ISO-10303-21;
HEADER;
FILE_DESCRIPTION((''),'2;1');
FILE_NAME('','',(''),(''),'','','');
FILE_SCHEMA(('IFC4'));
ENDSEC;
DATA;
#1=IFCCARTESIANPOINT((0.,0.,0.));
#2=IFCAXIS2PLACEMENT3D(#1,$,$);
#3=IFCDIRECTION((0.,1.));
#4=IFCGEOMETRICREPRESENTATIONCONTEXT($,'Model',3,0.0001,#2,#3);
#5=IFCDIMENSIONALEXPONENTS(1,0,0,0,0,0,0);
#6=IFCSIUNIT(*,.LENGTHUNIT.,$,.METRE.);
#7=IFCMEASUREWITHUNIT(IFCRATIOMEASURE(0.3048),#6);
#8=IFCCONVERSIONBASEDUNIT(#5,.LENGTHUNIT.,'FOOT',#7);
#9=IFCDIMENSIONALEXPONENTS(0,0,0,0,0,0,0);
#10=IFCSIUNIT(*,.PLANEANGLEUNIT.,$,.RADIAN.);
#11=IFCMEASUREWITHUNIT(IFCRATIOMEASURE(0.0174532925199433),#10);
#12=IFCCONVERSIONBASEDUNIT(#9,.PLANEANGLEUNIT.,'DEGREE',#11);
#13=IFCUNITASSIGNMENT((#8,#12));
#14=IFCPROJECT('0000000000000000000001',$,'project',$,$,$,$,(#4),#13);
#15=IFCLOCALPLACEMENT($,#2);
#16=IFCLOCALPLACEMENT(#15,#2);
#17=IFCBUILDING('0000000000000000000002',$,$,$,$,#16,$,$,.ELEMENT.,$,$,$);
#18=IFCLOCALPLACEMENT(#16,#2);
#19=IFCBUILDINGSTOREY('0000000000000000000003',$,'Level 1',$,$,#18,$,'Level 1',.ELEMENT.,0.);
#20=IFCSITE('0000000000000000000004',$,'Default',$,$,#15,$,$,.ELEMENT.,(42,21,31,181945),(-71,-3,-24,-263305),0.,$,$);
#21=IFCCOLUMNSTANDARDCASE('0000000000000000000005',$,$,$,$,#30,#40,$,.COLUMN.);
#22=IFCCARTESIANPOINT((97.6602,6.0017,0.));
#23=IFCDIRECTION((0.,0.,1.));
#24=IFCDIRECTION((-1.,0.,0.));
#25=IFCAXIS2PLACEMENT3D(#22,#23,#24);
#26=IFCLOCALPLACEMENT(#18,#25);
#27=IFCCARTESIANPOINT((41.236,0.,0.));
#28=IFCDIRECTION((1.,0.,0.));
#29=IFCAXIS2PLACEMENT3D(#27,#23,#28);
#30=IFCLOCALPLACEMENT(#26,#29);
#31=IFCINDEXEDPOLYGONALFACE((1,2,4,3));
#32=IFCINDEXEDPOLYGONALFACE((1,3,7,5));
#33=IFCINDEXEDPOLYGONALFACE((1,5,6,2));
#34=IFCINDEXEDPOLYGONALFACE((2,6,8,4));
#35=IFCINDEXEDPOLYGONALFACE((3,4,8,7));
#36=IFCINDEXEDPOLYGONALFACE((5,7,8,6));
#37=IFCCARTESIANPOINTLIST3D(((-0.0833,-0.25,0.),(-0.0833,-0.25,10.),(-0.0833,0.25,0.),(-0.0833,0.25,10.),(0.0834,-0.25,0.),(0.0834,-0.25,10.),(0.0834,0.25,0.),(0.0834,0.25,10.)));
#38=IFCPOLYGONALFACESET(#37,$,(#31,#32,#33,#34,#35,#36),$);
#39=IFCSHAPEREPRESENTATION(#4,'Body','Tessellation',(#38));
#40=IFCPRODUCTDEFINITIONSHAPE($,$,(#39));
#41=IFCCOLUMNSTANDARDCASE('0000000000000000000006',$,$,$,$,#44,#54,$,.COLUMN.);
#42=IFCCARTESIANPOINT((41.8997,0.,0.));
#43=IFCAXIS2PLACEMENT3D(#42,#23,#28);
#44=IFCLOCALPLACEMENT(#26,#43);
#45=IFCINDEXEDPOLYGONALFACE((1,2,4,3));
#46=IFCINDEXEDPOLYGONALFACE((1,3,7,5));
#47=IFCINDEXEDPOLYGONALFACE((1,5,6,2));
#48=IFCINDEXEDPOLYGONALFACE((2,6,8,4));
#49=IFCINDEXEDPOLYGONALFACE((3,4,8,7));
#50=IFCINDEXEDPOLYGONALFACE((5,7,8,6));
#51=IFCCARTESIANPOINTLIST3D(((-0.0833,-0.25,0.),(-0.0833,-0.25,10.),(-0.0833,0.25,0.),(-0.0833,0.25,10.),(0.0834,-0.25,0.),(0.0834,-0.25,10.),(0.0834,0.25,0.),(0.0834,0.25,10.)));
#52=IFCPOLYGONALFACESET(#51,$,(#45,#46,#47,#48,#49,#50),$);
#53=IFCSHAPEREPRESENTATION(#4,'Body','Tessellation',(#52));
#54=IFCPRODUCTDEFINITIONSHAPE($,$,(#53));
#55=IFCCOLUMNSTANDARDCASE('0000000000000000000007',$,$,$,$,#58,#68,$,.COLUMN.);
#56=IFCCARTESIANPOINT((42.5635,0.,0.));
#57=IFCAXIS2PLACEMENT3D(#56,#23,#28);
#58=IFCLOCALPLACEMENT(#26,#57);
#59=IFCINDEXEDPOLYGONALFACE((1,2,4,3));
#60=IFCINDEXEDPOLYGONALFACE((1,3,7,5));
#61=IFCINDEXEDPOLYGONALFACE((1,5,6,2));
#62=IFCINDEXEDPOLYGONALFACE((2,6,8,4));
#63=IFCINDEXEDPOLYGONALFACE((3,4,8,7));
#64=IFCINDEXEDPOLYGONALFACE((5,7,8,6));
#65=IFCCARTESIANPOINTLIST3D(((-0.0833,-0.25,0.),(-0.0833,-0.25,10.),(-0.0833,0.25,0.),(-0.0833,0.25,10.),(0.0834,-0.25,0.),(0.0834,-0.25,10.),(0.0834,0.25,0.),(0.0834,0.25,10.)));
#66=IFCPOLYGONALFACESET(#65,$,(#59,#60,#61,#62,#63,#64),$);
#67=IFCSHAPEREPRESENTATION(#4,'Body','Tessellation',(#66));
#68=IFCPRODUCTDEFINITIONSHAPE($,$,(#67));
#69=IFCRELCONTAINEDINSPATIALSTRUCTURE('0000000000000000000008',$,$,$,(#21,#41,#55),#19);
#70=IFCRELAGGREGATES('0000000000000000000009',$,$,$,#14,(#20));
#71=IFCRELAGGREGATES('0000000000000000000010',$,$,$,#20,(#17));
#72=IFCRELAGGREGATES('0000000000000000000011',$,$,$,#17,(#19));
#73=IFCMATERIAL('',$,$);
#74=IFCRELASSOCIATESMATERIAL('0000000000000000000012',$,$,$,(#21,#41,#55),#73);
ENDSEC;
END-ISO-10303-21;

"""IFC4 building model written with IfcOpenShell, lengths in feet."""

from ifc_helpers import new_model, entity, si_unit, converted_unit, direction, frame, origin, place, context, project, spatial, rectangle, extrude, material, element, save


model = new_model("IFC4")

# Units and contexts
model_context = context("Model", 3, precision=0.0001, world=origin(), true_north=direction((0.0, 1.0)))
ifc_project = project(units=[converted_unit("LENGTHUNIT", "FOOT", entity("IfcRatioMeasure", 0.3048), si_unit("LENGTHUNIT", "METRE"), dimensions=[1, 0, 0, 0, 0, 0, 0]), converted_unit("PLANEANGLEUNIT", "DEGREE", entity("IfcRatioMeasure", 0.0174532925199433), si_unit("PLANEANGLEUNIT", "RADIAN"), dimensions=[0, 0, 0, 0, 0, 0, 0])], contexts=[model_context])

# Site, building, storey
site_placement = place(None, origin())
site = spatial("IfcSite", under=ifc_project, at=site_placement, Name="Default", CompositionType="ELEMENT", RefLatitude=(42, 21, 31, 181945), RefLongitude=(-71, -3, -24, -263305), RefElevation=0.0)
building_placement = place(site_placement, origin())
building = spatial("IfcBuilding", under=site, at=building_placement, CompositionType="ELEMENT")
storey_placement = place(building_placement, origin())
storey = spatial("IfcBuildingStorey", under=building, at=storey_placement, Name="Level 1", LongName="Level 1", CompositionType="ELEMENT", Elevation=0.0)

# Columns
ifc_material_1 = material(Name="")
placement = place(storey_placement, frame((97.6602, 6.0017, 0.0), z_axis=(0.0, 0.0, 1.0), x_axis=(-1.0, 0.0, 0.0)))
for number, where, z_axis, x_axis in (
    (1, (41.236, 0.0, 0.0), (0.0, 0.0, 1.0), (1.0, 0.0, 0.0)),
    (2, (41.8997, 0.0, 0.0), (0.0, 0.0, 1.0), (1.0, 0.0, 0.0)),
    (3, (42.5635, 0.0, 0.0), (0.0, 0.0, 1.0), (1.0, 0.0, 0.0)),
):
    element("IfcColumnStandardCase", number, at=place(placement, frame(where, z_axis=z_axis, x_axis=x_axis)), inside=storey, material=ifc_material_1, PredefinedType="COLUMN", context=model_context, shape_type="SweptSolid", body=[
        extrude(rectangle(XDim=0.1667, YDim=0.5), origin(), (0.0, 0.0, 1.0), 10.0),
    ])

save(model, "model.ifc")
